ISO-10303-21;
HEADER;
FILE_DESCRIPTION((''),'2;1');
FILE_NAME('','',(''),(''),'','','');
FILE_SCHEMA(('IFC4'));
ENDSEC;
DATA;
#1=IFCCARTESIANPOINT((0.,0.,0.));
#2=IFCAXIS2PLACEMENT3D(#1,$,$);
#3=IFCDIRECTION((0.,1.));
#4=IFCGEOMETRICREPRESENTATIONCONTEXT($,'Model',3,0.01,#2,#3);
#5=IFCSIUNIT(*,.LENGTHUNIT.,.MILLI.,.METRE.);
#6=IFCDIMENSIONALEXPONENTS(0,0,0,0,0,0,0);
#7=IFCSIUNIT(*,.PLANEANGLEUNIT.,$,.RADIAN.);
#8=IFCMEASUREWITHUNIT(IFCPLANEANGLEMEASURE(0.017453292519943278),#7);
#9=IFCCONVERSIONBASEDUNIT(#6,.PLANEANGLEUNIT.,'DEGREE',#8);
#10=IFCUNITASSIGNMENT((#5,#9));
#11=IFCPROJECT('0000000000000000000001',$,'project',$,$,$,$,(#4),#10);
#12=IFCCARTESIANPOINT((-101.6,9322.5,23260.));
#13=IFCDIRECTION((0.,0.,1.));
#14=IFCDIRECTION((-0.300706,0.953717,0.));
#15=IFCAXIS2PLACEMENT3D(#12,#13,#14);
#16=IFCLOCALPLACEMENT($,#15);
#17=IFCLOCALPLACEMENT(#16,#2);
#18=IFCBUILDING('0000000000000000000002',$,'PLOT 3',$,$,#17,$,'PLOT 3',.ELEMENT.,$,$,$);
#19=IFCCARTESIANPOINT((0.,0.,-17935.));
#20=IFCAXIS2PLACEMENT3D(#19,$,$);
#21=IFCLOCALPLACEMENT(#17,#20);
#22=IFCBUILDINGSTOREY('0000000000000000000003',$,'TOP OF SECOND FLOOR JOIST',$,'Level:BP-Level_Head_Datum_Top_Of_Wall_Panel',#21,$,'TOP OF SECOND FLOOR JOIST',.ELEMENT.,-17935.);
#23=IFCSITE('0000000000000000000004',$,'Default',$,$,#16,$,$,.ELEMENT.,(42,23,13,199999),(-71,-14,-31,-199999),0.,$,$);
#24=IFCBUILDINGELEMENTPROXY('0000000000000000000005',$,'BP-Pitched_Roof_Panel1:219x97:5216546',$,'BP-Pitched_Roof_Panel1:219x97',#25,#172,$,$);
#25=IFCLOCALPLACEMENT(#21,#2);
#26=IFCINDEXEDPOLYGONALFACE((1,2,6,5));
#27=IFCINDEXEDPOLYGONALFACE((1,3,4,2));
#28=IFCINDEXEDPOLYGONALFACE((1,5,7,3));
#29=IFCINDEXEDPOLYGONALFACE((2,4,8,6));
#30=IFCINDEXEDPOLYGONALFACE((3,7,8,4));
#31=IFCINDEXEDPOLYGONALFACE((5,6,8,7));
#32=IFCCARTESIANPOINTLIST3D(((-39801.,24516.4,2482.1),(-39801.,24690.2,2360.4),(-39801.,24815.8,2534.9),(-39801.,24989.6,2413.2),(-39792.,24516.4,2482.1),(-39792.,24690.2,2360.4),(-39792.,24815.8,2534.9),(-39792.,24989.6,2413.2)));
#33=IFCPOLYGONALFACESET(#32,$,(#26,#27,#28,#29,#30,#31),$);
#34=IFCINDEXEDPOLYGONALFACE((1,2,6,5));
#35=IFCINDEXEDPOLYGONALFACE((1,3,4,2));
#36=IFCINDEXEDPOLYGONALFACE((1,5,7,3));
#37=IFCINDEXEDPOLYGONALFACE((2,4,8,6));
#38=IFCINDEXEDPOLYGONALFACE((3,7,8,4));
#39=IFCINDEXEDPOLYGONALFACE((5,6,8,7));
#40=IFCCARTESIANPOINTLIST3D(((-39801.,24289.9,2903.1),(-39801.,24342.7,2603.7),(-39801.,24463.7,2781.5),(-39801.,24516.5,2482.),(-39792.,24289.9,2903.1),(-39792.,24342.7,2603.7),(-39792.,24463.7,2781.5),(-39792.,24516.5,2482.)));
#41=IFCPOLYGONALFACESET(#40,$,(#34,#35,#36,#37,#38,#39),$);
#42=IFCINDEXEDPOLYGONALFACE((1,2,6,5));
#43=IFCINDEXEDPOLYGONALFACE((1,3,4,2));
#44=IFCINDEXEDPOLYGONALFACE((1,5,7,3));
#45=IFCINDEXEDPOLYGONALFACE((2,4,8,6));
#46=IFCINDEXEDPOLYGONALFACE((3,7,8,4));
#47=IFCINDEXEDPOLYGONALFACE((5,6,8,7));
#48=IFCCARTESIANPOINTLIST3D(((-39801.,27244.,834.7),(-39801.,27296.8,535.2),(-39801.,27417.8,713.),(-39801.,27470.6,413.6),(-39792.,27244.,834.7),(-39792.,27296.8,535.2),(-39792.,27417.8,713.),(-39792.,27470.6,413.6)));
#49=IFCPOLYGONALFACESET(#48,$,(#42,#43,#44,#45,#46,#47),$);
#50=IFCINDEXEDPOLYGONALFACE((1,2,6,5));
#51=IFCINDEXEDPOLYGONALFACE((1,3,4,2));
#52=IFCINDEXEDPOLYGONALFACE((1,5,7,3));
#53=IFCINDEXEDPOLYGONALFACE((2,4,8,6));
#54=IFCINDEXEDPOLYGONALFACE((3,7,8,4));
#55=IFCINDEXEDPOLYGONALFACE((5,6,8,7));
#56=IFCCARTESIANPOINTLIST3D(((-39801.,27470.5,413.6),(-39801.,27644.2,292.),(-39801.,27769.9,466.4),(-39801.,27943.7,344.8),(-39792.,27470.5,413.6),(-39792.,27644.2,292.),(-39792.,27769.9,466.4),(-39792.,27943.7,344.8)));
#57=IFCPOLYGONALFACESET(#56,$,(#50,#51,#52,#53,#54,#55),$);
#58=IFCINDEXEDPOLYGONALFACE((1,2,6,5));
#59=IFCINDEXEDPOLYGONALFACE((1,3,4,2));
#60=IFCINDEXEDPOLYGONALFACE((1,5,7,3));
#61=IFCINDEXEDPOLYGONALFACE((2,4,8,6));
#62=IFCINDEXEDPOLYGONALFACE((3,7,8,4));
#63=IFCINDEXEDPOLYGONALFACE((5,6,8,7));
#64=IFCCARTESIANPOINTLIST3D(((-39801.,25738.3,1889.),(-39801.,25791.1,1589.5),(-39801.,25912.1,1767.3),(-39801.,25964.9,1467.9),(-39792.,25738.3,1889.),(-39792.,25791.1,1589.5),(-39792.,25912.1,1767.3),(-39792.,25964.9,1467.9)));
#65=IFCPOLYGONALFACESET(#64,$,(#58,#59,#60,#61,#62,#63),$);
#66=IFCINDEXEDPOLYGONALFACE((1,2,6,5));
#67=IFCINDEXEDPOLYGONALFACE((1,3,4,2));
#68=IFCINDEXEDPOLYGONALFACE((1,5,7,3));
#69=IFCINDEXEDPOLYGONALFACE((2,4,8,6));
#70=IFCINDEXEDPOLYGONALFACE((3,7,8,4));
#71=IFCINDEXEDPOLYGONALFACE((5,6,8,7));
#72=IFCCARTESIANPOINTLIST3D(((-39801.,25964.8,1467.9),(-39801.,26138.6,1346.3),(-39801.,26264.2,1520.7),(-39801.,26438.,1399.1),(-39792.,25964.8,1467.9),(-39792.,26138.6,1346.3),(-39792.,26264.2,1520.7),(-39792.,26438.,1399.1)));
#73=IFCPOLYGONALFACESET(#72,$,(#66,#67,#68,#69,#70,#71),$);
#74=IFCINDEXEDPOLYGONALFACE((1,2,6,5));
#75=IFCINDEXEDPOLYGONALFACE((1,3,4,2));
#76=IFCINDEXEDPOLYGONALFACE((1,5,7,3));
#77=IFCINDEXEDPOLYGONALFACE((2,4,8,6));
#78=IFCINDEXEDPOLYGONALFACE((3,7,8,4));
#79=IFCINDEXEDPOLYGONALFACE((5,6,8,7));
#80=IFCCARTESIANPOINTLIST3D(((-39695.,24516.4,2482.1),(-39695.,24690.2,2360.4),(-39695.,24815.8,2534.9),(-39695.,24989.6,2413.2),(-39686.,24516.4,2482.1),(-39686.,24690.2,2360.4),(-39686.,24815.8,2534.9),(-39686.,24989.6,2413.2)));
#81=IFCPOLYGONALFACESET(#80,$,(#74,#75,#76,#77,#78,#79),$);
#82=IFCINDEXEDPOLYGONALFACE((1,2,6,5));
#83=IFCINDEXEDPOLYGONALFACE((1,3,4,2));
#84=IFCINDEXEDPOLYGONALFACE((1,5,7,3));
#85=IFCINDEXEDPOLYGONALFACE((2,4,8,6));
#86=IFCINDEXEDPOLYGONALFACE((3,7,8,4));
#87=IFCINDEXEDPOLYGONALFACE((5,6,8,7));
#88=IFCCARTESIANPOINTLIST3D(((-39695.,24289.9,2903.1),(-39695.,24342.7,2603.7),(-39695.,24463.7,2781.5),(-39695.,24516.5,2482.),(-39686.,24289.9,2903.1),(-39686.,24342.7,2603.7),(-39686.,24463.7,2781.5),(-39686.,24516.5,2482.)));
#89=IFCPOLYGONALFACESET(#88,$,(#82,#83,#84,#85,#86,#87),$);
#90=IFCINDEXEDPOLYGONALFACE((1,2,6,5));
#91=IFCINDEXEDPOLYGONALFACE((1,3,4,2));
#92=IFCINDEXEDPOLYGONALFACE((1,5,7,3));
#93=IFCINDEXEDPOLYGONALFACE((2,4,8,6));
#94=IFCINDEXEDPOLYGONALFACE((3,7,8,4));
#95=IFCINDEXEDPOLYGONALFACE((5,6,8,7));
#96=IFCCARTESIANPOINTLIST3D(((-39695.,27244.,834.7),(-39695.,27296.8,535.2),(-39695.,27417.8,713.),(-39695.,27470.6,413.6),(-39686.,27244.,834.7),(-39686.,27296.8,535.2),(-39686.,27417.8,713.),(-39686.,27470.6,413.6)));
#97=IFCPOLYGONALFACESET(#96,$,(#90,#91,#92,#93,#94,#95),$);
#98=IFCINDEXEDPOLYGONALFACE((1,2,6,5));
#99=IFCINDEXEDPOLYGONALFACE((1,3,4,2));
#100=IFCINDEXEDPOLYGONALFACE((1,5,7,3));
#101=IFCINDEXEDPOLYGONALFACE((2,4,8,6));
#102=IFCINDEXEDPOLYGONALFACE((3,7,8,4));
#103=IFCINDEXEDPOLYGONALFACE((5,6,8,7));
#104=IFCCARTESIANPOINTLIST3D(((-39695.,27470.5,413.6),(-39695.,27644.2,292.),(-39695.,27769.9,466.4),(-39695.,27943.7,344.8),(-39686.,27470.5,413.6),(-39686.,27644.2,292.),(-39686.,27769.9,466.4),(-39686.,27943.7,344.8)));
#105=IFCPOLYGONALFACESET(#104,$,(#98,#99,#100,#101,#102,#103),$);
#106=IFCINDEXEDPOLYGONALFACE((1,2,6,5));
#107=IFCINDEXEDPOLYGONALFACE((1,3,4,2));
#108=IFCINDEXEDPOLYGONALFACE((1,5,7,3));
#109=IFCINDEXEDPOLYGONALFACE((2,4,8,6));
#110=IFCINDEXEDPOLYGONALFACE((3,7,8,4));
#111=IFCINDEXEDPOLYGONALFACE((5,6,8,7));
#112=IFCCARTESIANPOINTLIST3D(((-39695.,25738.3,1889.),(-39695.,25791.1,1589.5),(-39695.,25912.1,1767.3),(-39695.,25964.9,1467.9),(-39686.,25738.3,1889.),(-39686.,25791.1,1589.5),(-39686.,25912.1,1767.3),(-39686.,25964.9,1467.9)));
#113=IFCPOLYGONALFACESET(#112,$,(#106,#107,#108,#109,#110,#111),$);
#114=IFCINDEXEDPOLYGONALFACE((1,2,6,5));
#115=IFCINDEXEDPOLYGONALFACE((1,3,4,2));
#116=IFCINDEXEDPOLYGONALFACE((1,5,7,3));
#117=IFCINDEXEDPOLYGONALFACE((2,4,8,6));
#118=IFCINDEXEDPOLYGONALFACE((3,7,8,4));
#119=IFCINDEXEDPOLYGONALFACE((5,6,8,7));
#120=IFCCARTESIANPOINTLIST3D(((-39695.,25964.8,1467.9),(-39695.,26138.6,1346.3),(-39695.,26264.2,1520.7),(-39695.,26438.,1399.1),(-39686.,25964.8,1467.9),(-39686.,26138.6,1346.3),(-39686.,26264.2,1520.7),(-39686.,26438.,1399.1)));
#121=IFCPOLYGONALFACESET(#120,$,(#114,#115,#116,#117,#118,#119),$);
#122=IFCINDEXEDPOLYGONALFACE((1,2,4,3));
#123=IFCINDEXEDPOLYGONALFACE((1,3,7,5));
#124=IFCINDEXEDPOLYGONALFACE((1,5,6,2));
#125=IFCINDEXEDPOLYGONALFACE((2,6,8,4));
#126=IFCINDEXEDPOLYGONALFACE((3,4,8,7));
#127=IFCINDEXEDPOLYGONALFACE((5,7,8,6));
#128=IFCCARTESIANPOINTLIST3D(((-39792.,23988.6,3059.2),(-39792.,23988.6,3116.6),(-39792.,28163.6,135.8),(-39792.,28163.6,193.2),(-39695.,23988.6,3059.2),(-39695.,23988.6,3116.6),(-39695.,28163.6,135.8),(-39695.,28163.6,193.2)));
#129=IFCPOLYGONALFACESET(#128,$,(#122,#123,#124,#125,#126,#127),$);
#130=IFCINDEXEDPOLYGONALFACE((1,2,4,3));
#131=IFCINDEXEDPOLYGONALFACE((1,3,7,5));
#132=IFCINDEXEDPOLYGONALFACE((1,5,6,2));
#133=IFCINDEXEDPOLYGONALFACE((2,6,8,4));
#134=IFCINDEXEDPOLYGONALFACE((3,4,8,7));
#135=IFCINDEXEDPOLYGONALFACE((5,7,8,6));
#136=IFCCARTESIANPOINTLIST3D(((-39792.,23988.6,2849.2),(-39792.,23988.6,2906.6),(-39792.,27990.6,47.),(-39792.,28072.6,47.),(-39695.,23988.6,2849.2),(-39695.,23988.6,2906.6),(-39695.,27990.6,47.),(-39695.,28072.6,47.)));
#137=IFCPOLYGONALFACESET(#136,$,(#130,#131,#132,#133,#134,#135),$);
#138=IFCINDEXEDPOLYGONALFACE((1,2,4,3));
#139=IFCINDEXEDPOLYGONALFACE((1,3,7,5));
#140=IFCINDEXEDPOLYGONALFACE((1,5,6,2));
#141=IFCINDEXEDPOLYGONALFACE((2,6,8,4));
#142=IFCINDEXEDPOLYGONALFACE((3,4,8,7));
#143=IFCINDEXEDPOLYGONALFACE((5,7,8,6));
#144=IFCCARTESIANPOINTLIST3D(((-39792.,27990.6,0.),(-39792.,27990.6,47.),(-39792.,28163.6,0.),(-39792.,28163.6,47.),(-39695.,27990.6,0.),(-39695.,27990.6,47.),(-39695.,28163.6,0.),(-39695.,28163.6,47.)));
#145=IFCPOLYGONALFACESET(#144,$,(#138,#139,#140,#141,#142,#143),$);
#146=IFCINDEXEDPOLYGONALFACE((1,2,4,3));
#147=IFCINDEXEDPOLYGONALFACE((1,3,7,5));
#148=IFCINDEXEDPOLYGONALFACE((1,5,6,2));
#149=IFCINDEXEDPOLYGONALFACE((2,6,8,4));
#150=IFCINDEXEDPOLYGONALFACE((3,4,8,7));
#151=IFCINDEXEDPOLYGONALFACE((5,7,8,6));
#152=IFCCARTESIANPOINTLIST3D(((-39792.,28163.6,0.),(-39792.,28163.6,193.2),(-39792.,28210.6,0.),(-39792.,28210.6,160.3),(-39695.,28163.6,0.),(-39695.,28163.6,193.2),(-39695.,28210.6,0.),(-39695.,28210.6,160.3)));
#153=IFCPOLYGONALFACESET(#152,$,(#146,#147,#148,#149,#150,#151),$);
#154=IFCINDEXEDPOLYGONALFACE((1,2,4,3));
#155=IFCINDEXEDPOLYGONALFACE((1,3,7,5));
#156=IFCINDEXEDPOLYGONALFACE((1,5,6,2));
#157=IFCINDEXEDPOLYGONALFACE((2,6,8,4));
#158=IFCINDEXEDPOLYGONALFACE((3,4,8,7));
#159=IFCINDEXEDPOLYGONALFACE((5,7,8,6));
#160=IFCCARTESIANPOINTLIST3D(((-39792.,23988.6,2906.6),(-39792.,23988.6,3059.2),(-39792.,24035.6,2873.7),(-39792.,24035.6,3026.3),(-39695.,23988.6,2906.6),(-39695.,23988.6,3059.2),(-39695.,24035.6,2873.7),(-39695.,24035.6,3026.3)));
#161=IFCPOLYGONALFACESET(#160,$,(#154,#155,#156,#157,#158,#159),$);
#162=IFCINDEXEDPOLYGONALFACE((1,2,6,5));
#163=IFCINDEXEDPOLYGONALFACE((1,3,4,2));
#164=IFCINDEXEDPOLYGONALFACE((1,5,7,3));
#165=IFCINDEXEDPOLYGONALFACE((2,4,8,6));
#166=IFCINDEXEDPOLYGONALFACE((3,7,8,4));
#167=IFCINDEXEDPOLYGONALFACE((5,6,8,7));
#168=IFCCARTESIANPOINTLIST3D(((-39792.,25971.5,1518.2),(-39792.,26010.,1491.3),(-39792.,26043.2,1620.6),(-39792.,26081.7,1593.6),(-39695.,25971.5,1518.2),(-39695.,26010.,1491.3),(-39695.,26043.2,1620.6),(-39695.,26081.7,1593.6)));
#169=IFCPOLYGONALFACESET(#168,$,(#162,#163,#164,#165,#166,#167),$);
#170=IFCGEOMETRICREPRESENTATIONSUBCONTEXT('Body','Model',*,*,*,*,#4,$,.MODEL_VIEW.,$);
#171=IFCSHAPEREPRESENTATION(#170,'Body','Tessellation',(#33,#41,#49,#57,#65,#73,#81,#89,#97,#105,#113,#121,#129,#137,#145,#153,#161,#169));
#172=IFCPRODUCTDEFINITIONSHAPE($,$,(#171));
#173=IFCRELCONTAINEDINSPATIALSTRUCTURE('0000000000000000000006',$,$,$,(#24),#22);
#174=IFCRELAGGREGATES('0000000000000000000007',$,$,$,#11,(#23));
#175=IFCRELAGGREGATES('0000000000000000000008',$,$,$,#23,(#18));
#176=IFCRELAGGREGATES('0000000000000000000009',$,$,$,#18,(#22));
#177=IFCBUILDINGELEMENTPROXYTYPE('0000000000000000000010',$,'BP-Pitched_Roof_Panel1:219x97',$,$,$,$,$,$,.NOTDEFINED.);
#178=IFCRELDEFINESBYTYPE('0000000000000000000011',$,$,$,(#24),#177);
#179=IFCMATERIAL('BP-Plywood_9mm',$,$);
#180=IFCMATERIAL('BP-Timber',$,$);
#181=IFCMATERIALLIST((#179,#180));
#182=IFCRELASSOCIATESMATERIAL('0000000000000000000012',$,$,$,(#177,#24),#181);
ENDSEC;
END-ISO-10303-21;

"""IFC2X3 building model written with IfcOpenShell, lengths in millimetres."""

from ifc_helpers import new_model, entity, si_unit, converted_unit, direction, frame, frame_2d, origin, origin_2d_with_axis, place, context, subcontext, project, spatial, polyline, rectangle, outline, extrude, source, transform, mapped, material, material_list, type_object, type_shapes, element, save


model = new_model("IFC2X3")

# Units and contexts
model_context = context("Model", 3, precision=0.01, world=origin(), true_north=direction((0.0, 1.0)))
body_context = subcontext(model_context, "Body", "Model", "MODEL_VIEW")
ifc_project = project(units=[si_unit("LENGTHUNIT", "METRE", prefix="MILLI"), converted_unit("PLANEANGLEUNIT", "DEGREE", entity("IfcPlaneAngleMeasure", 0.017453292519943278), si_unit("PLANEANGLEUNIT", "RADIAN"), dimensions=[0, 0, 0, 0, 0, 0, 0])], contexts=[model_context])

# Site, building, storey
site_placement = place(None, frame((-101.6, 9322.5, 23260.0), z_axis=(0.0, 0.0, 1.0), x_axis=(-0.300706, 0.953717, 0.0)))
site = spatial("IfcSite", under=ifc_project, at=site_placement, Name="Default", CompositionType="ELEMENT", RefLatitude=(42, 23, 13, 199999), RefLongitude=(-71, -14, -31, -199999), RefElevation=0.0)
building_placement = place(site_placement, origin())
building = spatial("IfcBuilding", under=site, at=building_placement, Name="PLOT 3", LongName="PLOT 3", CompositionType="ELEMENT")
storey_placement = place(building_placement, frame((0.0, 0.0, -17935.0)))
storey = spatial("IfcBuildingStorey", under=building, at=storey_placement, Name="TOP OF SECOND FLOOR JOIST", ObjectType="Level:BP-Level_Head_Datum_Top_Of_Wall_Panel", LongName="TOP OF SECOND FLOOR JOIST", CompositionType="ELEMENT", Elevation=-17935.0)

# Building element proxy
ifc_material_1 = material(Name="BP-Timber")
ifc_material_2 = material(Name="BP-Plywood_9mm")
ifc_material_list = material_list([ifc_material_2, ifc_material_1])
building_element_proxy_type_1 = type_object("IfcBuildingElementProxyType", Name="BP-Pitched_Roof_Panel1:219x97", PredefinedType="NOTDEFINED", material=ifc_material_list)
shared_shape_1 = source(origin(), body_context, "Body", "SweptSolid", [
    extrude(outline(polyline([(-77.0, -75.0), (227.0, -75.0), (77.0, 75.0), (-227.0, 75.0), (-77.0, -75.0)])), frame((35.3, -3956.0, 2447.7), z_axis=(0.0, 1.0, 0.0), x_axis=(-0.984808, 0.0, 0.173648)), (0.0, 0.0, 1.0), 9.0),
    extrude(outline(polyline([(1.4, -107.5), (213.6, -107.5), (-1.4, 107.5), (-213.6, 107.5), (1.4, -107.5)])), frame((385.1, -3956.0, 2692.6), z_axis=(0.0, 1.0, 0.0), x_axis=(-0.819152, 0.0, -0.573576)), (0.0, 0.0, 1.0), 9.0),
    extrude(outline(polyline([(1.4, -107.5), (213.6, -107.5), (-1.4, 107.5), (-213.6, 107.5), (1.4, -107.5)])), frame((-2569.0, -3956.0, 624.1), z_axis=(0.0, 1.0, 0.0), x_axis=(-0.819152, 0.0, -0.573576)), (0.0, 0.0, 1.0), 9.0),
    extrude(outline(polyline([(-77.0, -75.0), (227.0, -75.0), (77.0, 75.0), (-227.0, 75.0), (-77.0, -75.0)])), frame((-2918.8, -3956.0, 379.2), z_axis=(0.0, 1.0, 0.0), x_axis=(-0.984808, 0.0, 0.173648)), (0.0, 0.0, 1.0), 9.0),
    extrude(outline(polyline([(1.4, -107.5), (213.6, -107.5), (-1.4, 107.5), (-213.6, 107.5), (1.4, -107.5)])), frame((-1063.3, -3956.0, 1678.4), z_axis=(0.0, 1.0, 0.0), x_axis=(-0.819152, 0.0, -0.573576)), (0.0, 0.0, 1.0), 9.0),
    extrude(outline(polyline([(-77.0, -75.0), (227.0, -75.0), (77.0, 75.0), (-227.0, 75.0), (-77.0, -75.0)])), frame((-1413.1, -3956.0, 1433.5), z_axis=(0.0, 1.0, 0.0), x_axis=(-0.984808, 0.0, 0.173648)), (0.0, 0.0, 1.0), 9.0),
    extrude(outline(polyline([(-77.0, -75.0), (227.0, -75.0), (77.0, 75.0), (-227.0, 75.0), (-77.0, -75.0)])), frame((35.3, -3850.0, 2447.7), z_axis=(0.0, 1.0, 0.0), x_axis=(-0.984808, 0.0, 0.173648)), (0.0, 0.0, 1.0), 9.0),
    extrude(outline(polyline([(1.4, -107.5), (213.6, -107.5), (-1.4, 107.5), (-213.6, 107.5), (1.4, -107.5)])), frame((385.1, -3850.0, 2692.6), z_axis=(0.0, 1.0, 0.0), x_axis=(-0.819152, 0.0, -0.573576)), (0.0, 0.0, 1.0), 9.0),
    extrude(outline(polyline([(1.4, -107.5), (213.6, -107.5), (-1.4, 107.5), (-213.6, 107.5), (1.4, -107.5)])), frame((-2569.0, -3850.0, 624.1), z_axis=(0.0, 1.0, 0.0), x_axis=(-0.819152, 0.0, -0.573576)), (0.0, 0.0, 1.0), 9.0),
    extrude(outline(polyline([(-77.0, -75.0), (227.0, -75.0), (77.0, 75.0), (-227.0, 75.0), (-77.0, -75.0)])), frame((-2918.8, -3850.0, 379.2), z_axis=(0.0, 1.0, 0.0), x_axis=(-0.984808, 0.0, 0.173648)), (0.0, 0.0, 1.0), 9.0),
    extrude(outline(polyline([(1.4, -107.5), (213.6, -107.5), (-1.4, 107.5), (-213.6, 107.5), (1.4, -107.5)])), frame((-1063.3, -3850.0, 1678.4), z_axis=(0.0, 1.0, 0.0), x_axis=(-0.819152, 0.0, -0.573576)), (0.0, 0.0, 1.0), 9.0),
    extrude(outline(polyline([(-77.0, -75.0), (227.0, -75.0), (77.0, 75.0), (-227.0, 75.0), (-77.0, -75.0)])), frame((-1413.1, -3850.0, 1433.5), z_axis=(0.0, 1.0, 0.0), x_axis=(-0.984808, 0.0, 0.173648)), (0.0, 0.0, 1.0), 9.0),
    extrude(outline(polyline([(-1490.4, -2087.5), (-1433.0, -2087.5), (1490.4, 2087.5), (1433.0, 2087.5), (-1490.4, -2087.5)])), frame((-1287.8, -3947.0, 1626.2), z_axis=(0.0, 1.0, 0.0), x_axis=(0.0, 0.0, -1.0)), (0.0, 0.0, 1.0), 97.0),
    extrude(outline(polyline([(-1444.1, -2021.5), (-1386.8, -2021.5), (1415.5, 1980.5), (1415.5, 2062.5), (-1444.1, -2021.5)])), frame((-1221.8, -3947.0, 1462.5), z_axis=(0.0, 1.0, 0.0), x_axis=(0.0, 0.0, -1.0)), (0.0, 0.0, 1.0), 97.0),
    extrude(rectangle(XDim=173.0, YDim=97.0, at=origin_2d_with_axis()), frame((-3288.8, -3898.5, 0.0), z_axis=(0.0, 0.0, 1.0), x_axis=(-1.0, 0.0, 0.0)), (0.0, 0.0, 1.0), 47.0),
    extrude(outline(polyline([(22.0, -72.4), (79.4, -72.4), (-31.4, 85.9), (-69.9, 58.9), (22.0, -72.4)])), frame((-3398.8, -3947.0, 88.4), z_axis=(0.0, 1.0, 0.0), x_axis=(0.819152, 0.0, 0.573576)), (0.0, 0.0, 1.0), 97.0),
    extrude(outline(polyline([(15.1, -62.5), (72.5, -62.5), (-15.1, 62.5), (-72.5, 62.5), (15.1, -62.5)])), frame((776.2, -3947.0, 2966.5), z_axis=(0.0, 1.0, 0.0), x_axis=(0.819152, 0.0, 0.573576)), (0.0, 0.0, 1.0), 97.0),
    extrude(rectangle(XDim=47.0, YDim=97.0, at=frame_2d((0.0, 0.0), x_axis=(1.0, 0.0))), frame((-1202.4, -3898.5, 1504.7), z_axis=(-0.573576, 0.0, 0.819152), x_axis=(-0.819152, 0.0, -0.573576)), (0.0, 0.0, 1.0), 125.0),
])
type_shapes(building_element_proxy_type_1, [shared_shape_1])
for number, where, z_axis, x_axis, name in (
    (1, (-35845.0, 24788.3, 0.0), (0.0, 0.0, 1.0), (0.0, -1.0, 0.0), "BP-Pitched_Roof_Panel1:219x97:5216546"),
):
    element("IfcBuildingElementProxy", number, at=place(storey_placement, frame(where, z_axis=z_axis, x_axis=x_axis)), inside=storey, type_object=building_element_proxy_type_1, material=ifc_material_list, Name=name, ObjectType="BP-Pitched_Roof_Panel1:219x97", context=body_context, shape_type="MappedRepresentation", body=[
        mapped(shared_shape_1, transform((0.0, 0.0, 0.0), scale=1.0)),
    ])

save(model, "model.ifc")
